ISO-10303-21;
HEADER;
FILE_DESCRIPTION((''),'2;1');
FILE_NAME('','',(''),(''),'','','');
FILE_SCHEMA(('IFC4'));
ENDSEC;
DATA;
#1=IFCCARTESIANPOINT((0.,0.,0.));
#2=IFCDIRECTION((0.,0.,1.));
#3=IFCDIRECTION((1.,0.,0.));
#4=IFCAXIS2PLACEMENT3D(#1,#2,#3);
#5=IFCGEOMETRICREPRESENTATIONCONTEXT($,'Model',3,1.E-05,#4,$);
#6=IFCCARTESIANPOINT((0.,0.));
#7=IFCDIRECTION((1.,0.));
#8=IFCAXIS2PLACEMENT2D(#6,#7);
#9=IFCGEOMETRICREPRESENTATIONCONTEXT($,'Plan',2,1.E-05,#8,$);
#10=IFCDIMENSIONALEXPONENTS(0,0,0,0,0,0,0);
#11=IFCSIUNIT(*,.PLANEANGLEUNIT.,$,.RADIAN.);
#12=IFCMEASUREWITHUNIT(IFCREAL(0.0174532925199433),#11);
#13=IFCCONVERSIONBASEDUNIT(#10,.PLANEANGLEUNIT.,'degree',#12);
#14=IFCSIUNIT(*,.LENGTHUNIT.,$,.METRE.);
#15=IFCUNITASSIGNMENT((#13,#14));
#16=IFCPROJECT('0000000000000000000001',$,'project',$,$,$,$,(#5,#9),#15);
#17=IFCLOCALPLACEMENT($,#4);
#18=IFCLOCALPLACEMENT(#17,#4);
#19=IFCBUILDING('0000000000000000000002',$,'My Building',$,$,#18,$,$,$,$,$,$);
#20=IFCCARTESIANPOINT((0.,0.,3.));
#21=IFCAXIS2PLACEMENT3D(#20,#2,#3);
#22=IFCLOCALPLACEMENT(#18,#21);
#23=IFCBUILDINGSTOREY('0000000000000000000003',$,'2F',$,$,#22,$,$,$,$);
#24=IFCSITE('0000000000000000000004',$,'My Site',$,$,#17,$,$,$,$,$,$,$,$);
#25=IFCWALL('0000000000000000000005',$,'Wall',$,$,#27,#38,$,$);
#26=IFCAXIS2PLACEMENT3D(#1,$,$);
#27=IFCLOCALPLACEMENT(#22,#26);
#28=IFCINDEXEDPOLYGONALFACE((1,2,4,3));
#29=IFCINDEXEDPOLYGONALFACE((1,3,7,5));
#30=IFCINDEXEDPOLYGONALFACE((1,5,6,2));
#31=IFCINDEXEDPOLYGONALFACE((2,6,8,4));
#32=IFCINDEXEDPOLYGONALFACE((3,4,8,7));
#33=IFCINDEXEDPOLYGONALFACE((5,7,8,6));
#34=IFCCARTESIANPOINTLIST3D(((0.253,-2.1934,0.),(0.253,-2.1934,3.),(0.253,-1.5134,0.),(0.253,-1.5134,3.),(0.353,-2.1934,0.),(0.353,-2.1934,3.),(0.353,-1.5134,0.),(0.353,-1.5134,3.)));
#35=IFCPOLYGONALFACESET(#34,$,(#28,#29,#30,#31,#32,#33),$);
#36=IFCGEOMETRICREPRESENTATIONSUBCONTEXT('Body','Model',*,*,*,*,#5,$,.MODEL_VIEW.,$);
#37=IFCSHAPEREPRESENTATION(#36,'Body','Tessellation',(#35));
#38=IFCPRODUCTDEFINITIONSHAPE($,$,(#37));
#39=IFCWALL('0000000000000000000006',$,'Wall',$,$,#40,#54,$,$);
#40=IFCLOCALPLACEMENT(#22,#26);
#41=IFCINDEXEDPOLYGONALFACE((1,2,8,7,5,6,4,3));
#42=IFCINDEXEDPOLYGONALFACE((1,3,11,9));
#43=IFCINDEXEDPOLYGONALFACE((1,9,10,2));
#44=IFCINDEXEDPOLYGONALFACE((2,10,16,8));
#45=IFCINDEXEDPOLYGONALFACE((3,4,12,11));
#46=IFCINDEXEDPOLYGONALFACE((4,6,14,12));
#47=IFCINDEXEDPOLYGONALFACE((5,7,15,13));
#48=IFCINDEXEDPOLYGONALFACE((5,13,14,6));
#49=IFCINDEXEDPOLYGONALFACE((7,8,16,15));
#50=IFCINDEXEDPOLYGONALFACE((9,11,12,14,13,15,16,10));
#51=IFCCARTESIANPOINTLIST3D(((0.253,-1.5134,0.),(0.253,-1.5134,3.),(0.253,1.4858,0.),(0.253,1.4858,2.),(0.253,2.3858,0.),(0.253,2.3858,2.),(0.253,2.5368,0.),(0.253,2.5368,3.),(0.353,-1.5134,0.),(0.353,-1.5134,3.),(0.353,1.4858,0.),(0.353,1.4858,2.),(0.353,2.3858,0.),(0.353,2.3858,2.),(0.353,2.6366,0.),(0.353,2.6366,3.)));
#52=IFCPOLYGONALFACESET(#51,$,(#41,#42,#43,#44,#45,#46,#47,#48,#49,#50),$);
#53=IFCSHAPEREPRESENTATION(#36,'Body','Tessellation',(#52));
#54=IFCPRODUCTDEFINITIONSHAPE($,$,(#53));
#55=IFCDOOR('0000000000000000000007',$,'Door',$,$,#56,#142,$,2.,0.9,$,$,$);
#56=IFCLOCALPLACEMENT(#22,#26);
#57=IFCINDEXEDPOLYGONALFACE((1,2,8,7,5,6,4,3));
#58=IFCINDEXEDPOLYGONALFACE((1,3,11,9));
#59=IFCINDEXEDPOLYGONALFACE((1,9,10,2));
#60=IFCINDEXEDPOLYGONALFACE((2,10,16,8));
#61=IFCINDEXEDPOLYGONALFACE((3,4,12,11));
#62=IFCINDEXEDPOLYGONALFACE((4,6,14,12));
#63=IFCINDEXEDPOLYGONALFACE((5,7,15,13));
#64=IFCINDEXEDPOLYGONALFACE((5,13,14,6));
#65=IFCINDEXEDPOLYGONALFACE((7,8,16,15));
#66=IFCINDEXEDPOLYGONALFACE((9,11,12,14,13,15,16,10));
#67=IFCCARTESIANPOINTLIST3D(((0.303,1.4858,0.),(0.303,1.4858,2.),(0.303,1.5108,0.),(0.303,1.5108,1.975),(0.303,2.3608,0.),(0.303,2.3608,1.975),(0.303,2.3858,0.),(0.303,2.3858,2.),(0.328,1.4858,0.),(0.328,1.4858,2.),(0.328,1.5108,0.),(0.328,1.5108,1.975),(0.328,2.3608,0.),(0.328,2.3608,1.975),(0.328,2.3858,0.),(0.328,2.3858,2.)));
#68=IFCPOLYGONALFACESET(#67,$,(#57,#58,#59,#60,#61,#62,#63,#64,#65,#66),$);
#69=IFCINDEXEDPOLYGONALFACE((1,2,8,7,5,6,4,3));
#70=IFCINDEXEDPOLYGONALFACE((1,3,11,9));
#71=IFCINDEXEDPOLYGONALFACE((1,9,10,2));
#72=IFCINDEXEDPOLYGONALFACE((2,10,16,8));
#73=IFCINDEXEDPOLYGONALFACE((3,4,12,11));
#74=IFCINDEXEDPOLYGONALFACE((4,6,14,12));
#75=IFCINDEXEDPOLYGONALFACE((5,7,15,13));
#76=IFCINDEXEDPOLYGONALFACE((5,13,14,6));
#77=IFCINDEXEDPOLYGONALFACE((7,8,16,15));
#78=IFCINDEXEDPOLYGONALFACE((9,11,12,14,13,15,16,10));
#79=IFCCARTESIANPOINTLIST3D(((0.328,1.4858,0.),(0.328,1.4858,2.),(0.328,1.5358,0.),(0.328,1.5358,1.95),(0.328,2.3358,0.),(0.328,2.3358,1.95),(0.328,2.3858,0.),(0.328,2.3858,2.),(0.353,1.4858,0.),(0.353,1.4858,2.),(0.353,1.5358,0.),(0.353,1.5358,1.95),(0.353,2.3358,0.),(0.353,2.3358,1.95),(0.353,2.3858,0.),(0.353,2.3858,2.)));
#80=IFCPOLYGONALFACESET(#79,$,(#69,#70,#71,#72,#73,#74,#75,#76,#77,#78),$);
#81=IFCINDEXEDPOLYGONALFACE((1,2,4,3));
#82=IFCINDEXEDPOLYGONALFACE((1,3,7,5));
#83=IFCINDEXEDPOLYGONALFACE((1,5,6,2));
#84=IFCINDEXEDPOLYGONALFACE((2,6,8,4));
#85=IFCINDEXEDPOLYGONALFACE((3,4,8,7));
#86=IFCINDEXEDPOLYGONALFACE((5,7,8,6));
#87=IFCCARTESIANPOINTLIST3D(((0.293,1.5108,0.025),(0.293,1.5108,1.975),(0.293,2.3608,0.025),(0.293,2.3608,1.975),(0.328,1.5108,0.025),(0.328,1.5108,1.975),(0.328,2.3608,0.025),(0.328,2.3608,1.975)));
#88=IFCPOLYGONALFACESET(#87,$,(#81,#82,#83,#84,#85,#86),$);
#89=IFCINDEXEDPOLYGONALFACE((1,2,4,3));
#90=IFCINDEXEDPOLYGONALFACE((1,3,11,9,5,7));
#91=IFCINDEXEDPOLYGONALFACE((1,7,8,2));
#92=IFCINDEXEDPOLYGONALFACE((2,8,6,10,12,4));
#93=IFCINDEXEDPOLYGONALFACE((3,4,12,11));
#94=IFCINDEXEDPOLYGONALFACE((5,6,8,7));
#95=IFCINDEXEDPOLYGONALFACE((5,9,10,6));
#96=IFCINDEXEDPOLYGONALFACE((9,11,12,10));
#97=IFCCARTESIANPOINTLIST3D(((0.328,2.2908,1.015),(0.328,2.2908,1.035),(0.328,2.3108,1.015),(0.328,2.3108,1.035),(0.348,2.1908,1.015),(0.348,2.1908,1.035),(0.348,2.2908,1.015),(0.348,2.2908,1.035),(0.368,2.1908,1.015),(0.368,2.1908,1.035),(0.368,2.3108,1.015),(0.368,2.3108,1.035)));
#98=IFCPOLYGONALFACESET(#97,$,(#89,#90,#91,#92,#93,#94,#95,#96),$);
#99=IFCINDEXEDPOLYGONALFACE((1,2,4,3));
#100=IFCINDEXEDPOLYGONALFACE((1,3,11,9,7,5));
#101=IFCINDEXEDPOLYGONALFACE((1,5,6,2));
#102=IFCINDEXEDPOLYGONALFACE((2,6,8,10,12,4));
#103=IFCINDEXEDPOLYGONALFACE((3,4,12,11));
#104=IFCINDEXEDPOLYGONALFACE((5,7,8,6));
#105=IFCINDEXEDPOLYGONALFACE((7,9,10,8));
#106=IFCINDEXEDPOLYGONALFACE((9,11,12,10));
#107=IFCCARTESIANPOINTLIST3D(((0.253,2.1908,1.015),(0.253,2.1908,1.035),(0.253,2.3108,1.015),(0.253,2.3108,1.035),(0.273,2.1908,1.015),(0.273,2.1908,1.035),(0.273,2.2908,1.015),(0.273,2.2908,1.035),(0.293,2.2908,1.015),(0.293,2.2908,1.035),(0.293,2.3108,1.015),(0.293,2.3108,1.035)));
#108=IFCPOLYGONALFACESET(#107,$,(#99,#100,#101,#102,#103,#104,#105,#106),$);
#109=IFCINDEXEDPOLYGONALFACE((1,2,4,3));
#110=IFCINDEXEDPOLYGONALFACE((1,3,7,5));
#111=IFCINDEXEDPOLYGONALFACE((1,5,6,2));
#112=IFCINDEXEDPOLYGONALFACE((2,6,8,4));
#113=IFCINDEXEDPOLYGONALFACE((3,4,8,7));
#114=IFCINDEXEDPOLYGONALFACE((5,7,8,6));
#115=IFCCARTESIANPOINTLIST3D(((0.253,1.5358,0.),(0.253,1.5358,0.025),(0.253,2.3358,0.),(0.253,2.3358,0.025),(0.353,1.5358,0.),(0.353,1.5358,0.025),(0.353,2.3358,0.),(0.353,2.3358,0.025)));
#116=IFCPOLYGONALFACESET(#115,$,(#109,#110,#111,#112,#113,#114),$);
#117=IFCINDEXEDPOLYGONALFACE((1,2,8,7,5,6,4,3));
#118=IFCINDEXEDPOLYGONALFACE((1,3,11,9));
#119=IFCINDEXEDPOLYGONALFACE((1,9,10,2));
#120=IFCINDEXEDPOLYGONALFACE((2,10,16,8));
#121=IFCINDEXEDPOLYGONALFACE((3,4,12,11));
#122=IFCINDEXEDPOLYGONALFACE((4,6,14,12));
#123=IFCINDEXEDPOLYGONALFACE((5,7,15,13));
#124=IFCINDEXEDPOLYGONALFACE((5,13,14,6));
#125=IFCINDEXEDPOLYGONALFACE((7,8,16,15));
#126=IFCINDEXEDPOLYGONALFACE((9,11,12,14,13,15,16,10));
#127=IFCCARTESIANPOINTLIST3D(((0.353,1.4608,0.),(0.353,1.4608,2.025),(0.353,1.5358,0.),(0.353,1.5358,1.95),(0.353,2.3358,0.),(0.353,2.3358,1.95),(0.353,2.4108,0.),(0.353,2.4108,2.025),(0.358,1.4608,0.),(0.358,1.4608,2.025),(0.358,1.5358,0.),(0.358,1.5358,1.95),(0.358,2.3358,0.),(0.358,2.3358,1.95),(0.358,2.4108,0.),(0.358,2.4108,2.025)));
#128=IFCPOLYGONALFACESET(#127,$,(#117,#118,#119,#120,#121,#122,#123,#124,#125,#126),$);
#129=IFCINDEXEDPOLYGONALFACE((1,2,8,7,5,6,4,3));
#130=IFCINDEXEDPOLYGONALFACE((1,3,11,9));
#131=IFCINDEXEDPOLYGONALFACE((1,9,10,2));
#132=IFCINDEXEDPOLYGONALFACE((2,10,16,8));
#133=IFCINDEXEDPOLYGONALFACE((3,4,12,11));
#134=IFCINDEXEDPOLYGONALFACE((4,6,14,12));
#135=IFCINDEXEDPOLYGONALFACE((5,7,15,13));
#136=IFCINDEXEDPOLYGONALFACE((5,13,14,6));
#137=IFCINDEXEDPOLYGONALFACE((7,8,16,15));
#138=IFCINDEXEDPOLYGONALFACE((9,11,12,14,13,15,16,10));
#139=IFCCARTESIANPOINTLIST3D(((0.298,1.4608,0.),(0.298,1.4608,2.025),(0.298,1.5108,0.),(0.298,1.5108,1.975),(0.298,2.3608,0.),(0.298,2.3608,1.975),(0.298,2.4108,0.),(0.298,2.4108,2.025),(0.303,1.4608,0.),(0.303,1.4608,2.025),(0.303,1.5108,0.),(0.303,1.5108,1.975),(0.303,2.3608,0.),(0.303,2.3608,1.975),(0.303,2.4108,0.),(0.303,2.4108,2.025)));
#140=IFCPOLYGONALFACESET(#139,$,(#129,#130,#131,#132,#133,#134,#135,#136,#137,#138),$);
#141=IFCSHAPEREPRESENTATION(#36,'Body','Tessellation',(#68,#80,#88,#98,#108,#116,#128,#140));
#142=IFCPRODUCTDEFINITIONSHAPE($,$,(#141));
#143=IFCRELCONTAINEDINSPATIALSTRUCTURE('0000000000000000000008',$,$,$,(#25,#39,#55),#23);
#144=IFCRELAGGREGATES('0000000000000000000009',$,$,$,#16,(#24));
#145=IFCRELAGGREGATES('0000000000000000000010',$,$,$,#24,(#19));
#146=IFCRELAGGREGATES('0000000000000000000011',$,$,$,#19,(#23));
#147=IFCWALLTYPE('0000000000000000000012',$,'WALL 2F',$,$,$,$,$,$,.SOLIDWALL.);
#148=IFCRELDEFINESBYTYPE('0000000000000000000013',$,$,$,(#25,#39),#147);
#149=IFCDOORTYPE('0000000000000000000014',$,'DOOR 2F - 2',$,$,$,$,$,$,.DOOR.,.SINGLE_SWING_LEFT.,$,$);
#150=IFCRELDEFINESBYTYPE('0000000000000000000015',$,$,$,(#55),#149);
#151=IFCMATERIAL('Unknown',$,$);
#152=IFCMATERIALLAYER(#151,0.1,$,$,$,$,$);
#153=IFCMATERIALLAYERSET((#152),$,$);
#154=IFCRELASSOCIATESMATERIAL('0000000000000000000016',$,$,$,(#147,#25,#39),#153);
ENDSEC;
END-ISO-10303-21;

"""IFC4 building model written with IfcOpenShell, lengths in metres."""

from ifc_helpers import new_model, entity, si_unit, converted_unit, frame, origin_with_axes, origin_2d_with_axis, place, context, subcontext, project, spatial, line, indexed_curve, outline, extrude, shape, source, transform, mapped, material, layer, layer_set, layer_usage, type_object, type_shapes, element, fill, save


model = new_model("IFC4")

# Units and contexts
model_context = context("Model", 3, precision=1e-05, world=origin_with_axes())
plan_context = context("Plan", 2, precision=1e-05, world=origin_2d_with_axis())
body_context_1 = subcontext(model_context, "Body", "Model", "MODEL_VIEW")
body_context_2 = subcontext(plan_context, "Body", "Plan", "PLAN_VIEW")
ifc_project = project(units=[converted_unit("PLANEANGLEUNIT", "degree", entity("IfcReal", 0.0174532925199433), si_unit("PLANEANGLEUNIT", "RADIAN"), dimensions=[0, 0, 0, 0, 0, 0, 0]), si_unit("LENGTHUNIT", "METRE")], contexts=[model_context, plan_context])

# Site, building, storey
site_placement = place(None, origin_with_axes())
site = spatial("IfcSite", under=ifc_project, at=site_placement, Name="My Site")
building_placement = place(site_placement, origin_with_axes())
building = spatial("IfcBuilding", under=site, at=building_placement, Name="My Building")
storey_placement = place(building_placement, frame((0.0, 0.0, 3.0), z_axis=(0.0, 0.0, 1.0), x_axis=(1.0, 0.0, 0.0)))
storey = spatial("IfcBuildingStorey", under=building, at=storey_placement, Name="2F")

# Shared definitions
ifc_material = material(Name="Unknown")
ifc_layer = layer(ifc_material, 0.1)
ifc_layer_set = layer_set([ifc_layer])
wall_type = type_object("IfcWallType", Name="WALL 2F", PredefinedType="SOLIDWALL", material=ifc_layer_set)

# Wall
ifc_layer_usage_1 = layer_usage(ifc_layer_set, "AXIS2", "POSITIVE", 0.0)
wall_1_placement = place(storey_placement, frame((0.253, -1.5134, 0.0), z_axis=(0.0, 0.0, 1.0), x_axis=(0.0, -1.0, 0.0)))
element("IfcWall", 1, at=wall_1_placement, inside=storey, type_object=wall_type, material=ifc_layer_usage_1, Name="Wall", context=body_context_1, shape_type="SweptSolid", body=[
    extrude(outline(indexed_curve([(0.0, 0.0), (0.0, 0.1), (0.68, 0.1), (0.68, 0.0)], segments=[line(1, 2, 3, 4, 1)])), origin_with_axes(), (0.0, 0.0, 1.0), 3.0),
])

# Wall, opening, door
ifc_layer_usage_2 = layer_usage(ifc_layer_set, "AXIS2", "POSITIVE", 0.0)
wall_2_placement = place(storey_placement, frame((0.353, -1.5134, 0.0), z_axis=(0.0, 0.0, 1.0), x_axis=(0.0, 1.0, 0.0)))
wall_2 = element("IfcWall", 2, at=wall_2_placement, inside=storey, type_object=wall_type, material=ifc_layer_usage_2, Name="Wall", context=body_context_1, shape_type="SweptSolid", body=[
    extrude(outline(indexed_curve([(0.0, 0.0), (0.0, 0.1), (4.0502, 0.1), (4.15, 0.0)], segments=[line(1, 2, 3, 4, 1)])), origin_with_axes(), (0.0, 0.0, 1.0), 3.0),
])
shared_shape_1 = source(origin_with_axes(), body_context_1, "Body", "SweptSolid", [
    extrude(outline(indexed_curve([(0.0, 0.0), (0.9, 0.0), (0.9, 2.0), (0.0, 2.0)], segments=[line(1, 2, 3, 4, 1)])), frame((0.0, -0.6, 0.0), z_axis=(0.0, -1.0, 0.0), x_axis=(1.0, 0.0, 0.0)), (0.0, 0.0, -1.0), 1.2),
])
opening_1_placement = place(wall_2_placement, frame((2.9992, 0.0, 0.0), z_axis=(0.0, 0.0, 1.0), x_axis=(1.0, 0.0, 0.0)))
opening_1 = element("IfcOpeningElement", 3, at=opening_1_placement, cuts=wall_2, PredefinedType="OPENING", context=body_context_1, shape_type="MappedRepresentation", body=[
    mapped(shared_shape_1, transform((0.0, 0.0, 0.0), x_axis=(1.0, 0.0, 0.0), y_axis=(0.0, 1.0, 0.0), z_axis=(0.0, 0.0, 1.0), scale=1.0)),
])
door_type_1 = type_object("IfcDoorType", Name="DOOR 2F - 2", OperationType="SINGLE_SWING_LEFT", PredefinedType="DOOR")
shared_shape_2 = source(origin_with_axes(), body_context_1, "Body", "SweptSolid", [
    extrude(outline(indexed_curve([(0.0, 0.0), (0.0, 2.0), (0.9, 2.0), (0.9, 0.0), (0.875, 0.0), (0.875, 1.975), (0.025, 1.975), (0.025, 0.0)], segments=[line(1, 2, 3, 4, 5, 6, 7, 8, 1)])), frame((0.0, 0.025, 0.0), z_axis=(0.0, -1.0, 0.0), x_axis=(1.0, 0.0, 0.0)), (0.0, 0.0, -1.0), 0.025),
    extrude(outline(indexed_curve([(0.0, 0.0), (0.0, 2.0), (0.9, 2.0), (0.9, 0.0), (0.85, 0.0), (0.85, 1.95), (0.05, 1.95), (0.05, 0.0)], segments=[line(1, 2, 3, 4, 5, 6, 7, 8, 1)])), frame((0.0, 0.0, 0.0), z_axis=(0.0, -1.0, 0.0), x_axis=(1.0, 0.0, 0.0)), (0.0, 0.0, -1.0), 0.025),
    extrude(outline(indexed_curve([(0.0, 0.0), (0.85, 0.0), (0.85, 0.035), (0.0, 0.035)], segments=[line(1, 2, 3, 4, 1)])), frame((0.025, 0.025, 0.025), z_axis=(0.0, 0.0, 1.0), x_axis=(1.0, 0.0, 0.0)), (0.0, 0.0, 1.0), 1.95),
    extrude(outline(indexed_curve([(0.0, 0.0), (0.0, -0.04), (-0.12, -0.04), (-0.12, -0.02), (-0.02, -0.02), (-0.02, 0.0)], segments=[line(1, 2, 3, 4, 5, 6, 1)])), frame((0.825, 0.025, 1.015), z_axis=(0.0, 0.0, 1.0), x_axis=(1.0, 0.0, 0.0)), (0.0, 0.0, 1.0), 0.02),
    extrude(outline(indexed_curve([(0.0, 0.0), (0.0, 0.04), (-0.12, 0.04), (-0.12, 0.02), (-0.02, 0.02), (-0.02, 0.0)], segments=[line(1, 2, 3, 4, 5, 6, 1)])), frame((0.825, 0.06, 1.015), z_axis=(0.0, 0.0, 1.0), x_axis=(1.0, 0.0, 0.0)), (0.0, 0.0, 1.0), 0.02),
    extrude(outline(indexed_curve([(0.0, 0.0), (0.8, 0.0), (0.8, 0.1), (0.0, 0.1)], segments=[line(1, 2, 3, 4, 1)])), frame((0.05, 0.0, 0.0), z_axis=(0.0, 0.0, 1.0), x_axis=(1.0, 0.0, 0.0)), (0.0, 0.0, 1.0), 0.025),
    extrude(outline(indexed_curve([(0.0, 0.0), (0.0, 2.025), (0.95, 2.025), (0.95, 0.0), (0.875, 0.0), (0.875, 1.95), (0.075, 1.95), (0.075, 0.0)], segments=[line(1, 2, 3, 4, 5, 6, 7, 8, 1)])), frame((-0.025, -0.005, 0.0), z_axis=(0.0, -1.0, 0.0), x_axis=(1.0, 0.0, 0.0)), (0.0, 0.0, -1.0), 0.005),
    extrude(outline(indexed_curve([(0.0, 0.0), (0.0, 2.025), (0.95, 2.025), (0.95, 0.0), (0.9, 0.0), (0.9, 1.975), (0.05, 1.975), (0.05, 0.0)], segments=[line(1, 2, 3, 4, 5, 6, 7, 8, 1)])), frame((-0.025, 0.05, 0.0), z_axis=(0.0, -1.0, 0.0), x_axis=(1.0, 0.0, 0.0)), (0.0, 0.0, -1.0), 0.005),
])
shared_shape_3 = source(origin_with_axes(), body_context_2, "Body", "Curve2D", [
    entity("IfcIndexedPolyCurve", entity("IfcCartesianPointList2D", [[0.0, 0.0], [0.0, 0.05], [0.025, 0.05], [0.025, 0.025], [0.05, 0.025], [0.05, 0.0]]), [entity("IfcLineIndex", [1, 2, 3, 4, 5, 6, 1])]),
    entity("IfcIndexedPolyCurve", entity("IfcCartesianPointList2D", [[0.9, 0.0], [0.9, 0.05], [0.875, 0.05], [0.875, 0.025], [0.85, 0.025], [0.85, 0.0]]), [entity("IfcLineIndex", [1, 2, 3, 4, 5, 6, 1])]),
    entity("IfcTrimmedCurve", entity("IfcEllipse", entity("IfcAxis2Placement2D", entity("IfcCartesianPoint", [0.06, 0.05]), entity("IfcDirection", [1.0, 0.0])), 0.815, 0.85), [entity("IfcCartesianPoint", [0.875, 0.05])], [entity("IfcCartesianPoint", [0.06, 0.9])], True, "CARTESIAN"),
    entity("IfcIndexedPolyCurve", entity("IfcCartesianPointList2D", [[0.025, 0.05], [0.06, 0.05], [0.06, 0.9], [0.025, 0.9]]), [entity("IfcLineIndex", [1, 2, 3, 4, 1])]),
])
type_shapes(door_type_1, [shared_shape_2, shared_shape_3])
door_1_placement = place(opening_1_placement, frame((0.0, 0.0, 0.0), z_axis=(0.0, 0.0, 1.0), x_axis=(1.0, 0.0, 0.0)))
door_1 = element("IfcDoor", 4, at=door_1_placement, inside=storey, type_object=door_type_1, Name="Door", OverallHeight=2.0, OverallWidth=0.9, shapes=[
    shape(body_context_1, "Body", "MappedRepresentation", [mapped(shared_shape_2, transform((0.0, 0.0, 0.0), x_axis=(1.0, 0.0, 0.0), y_axis=(0.0, 1.0, 0.0), z_axis=(0.0, 0.0, 1.0), scale=1.0))]),
    shape(body_context_2, "Body", "MappedRepresentation", [mapped(shared_shape_3, transform((0.0, 0.0, 0.0), x_axis=(1.0, 0.0, 0.0), y_axis=(0.0, 1.0, 0.0), z_axis=(0.0, 0.0, 1.0), scale=1.0))]),
])
fill(opening_1, door_1)

save(model, "model.ifc")
